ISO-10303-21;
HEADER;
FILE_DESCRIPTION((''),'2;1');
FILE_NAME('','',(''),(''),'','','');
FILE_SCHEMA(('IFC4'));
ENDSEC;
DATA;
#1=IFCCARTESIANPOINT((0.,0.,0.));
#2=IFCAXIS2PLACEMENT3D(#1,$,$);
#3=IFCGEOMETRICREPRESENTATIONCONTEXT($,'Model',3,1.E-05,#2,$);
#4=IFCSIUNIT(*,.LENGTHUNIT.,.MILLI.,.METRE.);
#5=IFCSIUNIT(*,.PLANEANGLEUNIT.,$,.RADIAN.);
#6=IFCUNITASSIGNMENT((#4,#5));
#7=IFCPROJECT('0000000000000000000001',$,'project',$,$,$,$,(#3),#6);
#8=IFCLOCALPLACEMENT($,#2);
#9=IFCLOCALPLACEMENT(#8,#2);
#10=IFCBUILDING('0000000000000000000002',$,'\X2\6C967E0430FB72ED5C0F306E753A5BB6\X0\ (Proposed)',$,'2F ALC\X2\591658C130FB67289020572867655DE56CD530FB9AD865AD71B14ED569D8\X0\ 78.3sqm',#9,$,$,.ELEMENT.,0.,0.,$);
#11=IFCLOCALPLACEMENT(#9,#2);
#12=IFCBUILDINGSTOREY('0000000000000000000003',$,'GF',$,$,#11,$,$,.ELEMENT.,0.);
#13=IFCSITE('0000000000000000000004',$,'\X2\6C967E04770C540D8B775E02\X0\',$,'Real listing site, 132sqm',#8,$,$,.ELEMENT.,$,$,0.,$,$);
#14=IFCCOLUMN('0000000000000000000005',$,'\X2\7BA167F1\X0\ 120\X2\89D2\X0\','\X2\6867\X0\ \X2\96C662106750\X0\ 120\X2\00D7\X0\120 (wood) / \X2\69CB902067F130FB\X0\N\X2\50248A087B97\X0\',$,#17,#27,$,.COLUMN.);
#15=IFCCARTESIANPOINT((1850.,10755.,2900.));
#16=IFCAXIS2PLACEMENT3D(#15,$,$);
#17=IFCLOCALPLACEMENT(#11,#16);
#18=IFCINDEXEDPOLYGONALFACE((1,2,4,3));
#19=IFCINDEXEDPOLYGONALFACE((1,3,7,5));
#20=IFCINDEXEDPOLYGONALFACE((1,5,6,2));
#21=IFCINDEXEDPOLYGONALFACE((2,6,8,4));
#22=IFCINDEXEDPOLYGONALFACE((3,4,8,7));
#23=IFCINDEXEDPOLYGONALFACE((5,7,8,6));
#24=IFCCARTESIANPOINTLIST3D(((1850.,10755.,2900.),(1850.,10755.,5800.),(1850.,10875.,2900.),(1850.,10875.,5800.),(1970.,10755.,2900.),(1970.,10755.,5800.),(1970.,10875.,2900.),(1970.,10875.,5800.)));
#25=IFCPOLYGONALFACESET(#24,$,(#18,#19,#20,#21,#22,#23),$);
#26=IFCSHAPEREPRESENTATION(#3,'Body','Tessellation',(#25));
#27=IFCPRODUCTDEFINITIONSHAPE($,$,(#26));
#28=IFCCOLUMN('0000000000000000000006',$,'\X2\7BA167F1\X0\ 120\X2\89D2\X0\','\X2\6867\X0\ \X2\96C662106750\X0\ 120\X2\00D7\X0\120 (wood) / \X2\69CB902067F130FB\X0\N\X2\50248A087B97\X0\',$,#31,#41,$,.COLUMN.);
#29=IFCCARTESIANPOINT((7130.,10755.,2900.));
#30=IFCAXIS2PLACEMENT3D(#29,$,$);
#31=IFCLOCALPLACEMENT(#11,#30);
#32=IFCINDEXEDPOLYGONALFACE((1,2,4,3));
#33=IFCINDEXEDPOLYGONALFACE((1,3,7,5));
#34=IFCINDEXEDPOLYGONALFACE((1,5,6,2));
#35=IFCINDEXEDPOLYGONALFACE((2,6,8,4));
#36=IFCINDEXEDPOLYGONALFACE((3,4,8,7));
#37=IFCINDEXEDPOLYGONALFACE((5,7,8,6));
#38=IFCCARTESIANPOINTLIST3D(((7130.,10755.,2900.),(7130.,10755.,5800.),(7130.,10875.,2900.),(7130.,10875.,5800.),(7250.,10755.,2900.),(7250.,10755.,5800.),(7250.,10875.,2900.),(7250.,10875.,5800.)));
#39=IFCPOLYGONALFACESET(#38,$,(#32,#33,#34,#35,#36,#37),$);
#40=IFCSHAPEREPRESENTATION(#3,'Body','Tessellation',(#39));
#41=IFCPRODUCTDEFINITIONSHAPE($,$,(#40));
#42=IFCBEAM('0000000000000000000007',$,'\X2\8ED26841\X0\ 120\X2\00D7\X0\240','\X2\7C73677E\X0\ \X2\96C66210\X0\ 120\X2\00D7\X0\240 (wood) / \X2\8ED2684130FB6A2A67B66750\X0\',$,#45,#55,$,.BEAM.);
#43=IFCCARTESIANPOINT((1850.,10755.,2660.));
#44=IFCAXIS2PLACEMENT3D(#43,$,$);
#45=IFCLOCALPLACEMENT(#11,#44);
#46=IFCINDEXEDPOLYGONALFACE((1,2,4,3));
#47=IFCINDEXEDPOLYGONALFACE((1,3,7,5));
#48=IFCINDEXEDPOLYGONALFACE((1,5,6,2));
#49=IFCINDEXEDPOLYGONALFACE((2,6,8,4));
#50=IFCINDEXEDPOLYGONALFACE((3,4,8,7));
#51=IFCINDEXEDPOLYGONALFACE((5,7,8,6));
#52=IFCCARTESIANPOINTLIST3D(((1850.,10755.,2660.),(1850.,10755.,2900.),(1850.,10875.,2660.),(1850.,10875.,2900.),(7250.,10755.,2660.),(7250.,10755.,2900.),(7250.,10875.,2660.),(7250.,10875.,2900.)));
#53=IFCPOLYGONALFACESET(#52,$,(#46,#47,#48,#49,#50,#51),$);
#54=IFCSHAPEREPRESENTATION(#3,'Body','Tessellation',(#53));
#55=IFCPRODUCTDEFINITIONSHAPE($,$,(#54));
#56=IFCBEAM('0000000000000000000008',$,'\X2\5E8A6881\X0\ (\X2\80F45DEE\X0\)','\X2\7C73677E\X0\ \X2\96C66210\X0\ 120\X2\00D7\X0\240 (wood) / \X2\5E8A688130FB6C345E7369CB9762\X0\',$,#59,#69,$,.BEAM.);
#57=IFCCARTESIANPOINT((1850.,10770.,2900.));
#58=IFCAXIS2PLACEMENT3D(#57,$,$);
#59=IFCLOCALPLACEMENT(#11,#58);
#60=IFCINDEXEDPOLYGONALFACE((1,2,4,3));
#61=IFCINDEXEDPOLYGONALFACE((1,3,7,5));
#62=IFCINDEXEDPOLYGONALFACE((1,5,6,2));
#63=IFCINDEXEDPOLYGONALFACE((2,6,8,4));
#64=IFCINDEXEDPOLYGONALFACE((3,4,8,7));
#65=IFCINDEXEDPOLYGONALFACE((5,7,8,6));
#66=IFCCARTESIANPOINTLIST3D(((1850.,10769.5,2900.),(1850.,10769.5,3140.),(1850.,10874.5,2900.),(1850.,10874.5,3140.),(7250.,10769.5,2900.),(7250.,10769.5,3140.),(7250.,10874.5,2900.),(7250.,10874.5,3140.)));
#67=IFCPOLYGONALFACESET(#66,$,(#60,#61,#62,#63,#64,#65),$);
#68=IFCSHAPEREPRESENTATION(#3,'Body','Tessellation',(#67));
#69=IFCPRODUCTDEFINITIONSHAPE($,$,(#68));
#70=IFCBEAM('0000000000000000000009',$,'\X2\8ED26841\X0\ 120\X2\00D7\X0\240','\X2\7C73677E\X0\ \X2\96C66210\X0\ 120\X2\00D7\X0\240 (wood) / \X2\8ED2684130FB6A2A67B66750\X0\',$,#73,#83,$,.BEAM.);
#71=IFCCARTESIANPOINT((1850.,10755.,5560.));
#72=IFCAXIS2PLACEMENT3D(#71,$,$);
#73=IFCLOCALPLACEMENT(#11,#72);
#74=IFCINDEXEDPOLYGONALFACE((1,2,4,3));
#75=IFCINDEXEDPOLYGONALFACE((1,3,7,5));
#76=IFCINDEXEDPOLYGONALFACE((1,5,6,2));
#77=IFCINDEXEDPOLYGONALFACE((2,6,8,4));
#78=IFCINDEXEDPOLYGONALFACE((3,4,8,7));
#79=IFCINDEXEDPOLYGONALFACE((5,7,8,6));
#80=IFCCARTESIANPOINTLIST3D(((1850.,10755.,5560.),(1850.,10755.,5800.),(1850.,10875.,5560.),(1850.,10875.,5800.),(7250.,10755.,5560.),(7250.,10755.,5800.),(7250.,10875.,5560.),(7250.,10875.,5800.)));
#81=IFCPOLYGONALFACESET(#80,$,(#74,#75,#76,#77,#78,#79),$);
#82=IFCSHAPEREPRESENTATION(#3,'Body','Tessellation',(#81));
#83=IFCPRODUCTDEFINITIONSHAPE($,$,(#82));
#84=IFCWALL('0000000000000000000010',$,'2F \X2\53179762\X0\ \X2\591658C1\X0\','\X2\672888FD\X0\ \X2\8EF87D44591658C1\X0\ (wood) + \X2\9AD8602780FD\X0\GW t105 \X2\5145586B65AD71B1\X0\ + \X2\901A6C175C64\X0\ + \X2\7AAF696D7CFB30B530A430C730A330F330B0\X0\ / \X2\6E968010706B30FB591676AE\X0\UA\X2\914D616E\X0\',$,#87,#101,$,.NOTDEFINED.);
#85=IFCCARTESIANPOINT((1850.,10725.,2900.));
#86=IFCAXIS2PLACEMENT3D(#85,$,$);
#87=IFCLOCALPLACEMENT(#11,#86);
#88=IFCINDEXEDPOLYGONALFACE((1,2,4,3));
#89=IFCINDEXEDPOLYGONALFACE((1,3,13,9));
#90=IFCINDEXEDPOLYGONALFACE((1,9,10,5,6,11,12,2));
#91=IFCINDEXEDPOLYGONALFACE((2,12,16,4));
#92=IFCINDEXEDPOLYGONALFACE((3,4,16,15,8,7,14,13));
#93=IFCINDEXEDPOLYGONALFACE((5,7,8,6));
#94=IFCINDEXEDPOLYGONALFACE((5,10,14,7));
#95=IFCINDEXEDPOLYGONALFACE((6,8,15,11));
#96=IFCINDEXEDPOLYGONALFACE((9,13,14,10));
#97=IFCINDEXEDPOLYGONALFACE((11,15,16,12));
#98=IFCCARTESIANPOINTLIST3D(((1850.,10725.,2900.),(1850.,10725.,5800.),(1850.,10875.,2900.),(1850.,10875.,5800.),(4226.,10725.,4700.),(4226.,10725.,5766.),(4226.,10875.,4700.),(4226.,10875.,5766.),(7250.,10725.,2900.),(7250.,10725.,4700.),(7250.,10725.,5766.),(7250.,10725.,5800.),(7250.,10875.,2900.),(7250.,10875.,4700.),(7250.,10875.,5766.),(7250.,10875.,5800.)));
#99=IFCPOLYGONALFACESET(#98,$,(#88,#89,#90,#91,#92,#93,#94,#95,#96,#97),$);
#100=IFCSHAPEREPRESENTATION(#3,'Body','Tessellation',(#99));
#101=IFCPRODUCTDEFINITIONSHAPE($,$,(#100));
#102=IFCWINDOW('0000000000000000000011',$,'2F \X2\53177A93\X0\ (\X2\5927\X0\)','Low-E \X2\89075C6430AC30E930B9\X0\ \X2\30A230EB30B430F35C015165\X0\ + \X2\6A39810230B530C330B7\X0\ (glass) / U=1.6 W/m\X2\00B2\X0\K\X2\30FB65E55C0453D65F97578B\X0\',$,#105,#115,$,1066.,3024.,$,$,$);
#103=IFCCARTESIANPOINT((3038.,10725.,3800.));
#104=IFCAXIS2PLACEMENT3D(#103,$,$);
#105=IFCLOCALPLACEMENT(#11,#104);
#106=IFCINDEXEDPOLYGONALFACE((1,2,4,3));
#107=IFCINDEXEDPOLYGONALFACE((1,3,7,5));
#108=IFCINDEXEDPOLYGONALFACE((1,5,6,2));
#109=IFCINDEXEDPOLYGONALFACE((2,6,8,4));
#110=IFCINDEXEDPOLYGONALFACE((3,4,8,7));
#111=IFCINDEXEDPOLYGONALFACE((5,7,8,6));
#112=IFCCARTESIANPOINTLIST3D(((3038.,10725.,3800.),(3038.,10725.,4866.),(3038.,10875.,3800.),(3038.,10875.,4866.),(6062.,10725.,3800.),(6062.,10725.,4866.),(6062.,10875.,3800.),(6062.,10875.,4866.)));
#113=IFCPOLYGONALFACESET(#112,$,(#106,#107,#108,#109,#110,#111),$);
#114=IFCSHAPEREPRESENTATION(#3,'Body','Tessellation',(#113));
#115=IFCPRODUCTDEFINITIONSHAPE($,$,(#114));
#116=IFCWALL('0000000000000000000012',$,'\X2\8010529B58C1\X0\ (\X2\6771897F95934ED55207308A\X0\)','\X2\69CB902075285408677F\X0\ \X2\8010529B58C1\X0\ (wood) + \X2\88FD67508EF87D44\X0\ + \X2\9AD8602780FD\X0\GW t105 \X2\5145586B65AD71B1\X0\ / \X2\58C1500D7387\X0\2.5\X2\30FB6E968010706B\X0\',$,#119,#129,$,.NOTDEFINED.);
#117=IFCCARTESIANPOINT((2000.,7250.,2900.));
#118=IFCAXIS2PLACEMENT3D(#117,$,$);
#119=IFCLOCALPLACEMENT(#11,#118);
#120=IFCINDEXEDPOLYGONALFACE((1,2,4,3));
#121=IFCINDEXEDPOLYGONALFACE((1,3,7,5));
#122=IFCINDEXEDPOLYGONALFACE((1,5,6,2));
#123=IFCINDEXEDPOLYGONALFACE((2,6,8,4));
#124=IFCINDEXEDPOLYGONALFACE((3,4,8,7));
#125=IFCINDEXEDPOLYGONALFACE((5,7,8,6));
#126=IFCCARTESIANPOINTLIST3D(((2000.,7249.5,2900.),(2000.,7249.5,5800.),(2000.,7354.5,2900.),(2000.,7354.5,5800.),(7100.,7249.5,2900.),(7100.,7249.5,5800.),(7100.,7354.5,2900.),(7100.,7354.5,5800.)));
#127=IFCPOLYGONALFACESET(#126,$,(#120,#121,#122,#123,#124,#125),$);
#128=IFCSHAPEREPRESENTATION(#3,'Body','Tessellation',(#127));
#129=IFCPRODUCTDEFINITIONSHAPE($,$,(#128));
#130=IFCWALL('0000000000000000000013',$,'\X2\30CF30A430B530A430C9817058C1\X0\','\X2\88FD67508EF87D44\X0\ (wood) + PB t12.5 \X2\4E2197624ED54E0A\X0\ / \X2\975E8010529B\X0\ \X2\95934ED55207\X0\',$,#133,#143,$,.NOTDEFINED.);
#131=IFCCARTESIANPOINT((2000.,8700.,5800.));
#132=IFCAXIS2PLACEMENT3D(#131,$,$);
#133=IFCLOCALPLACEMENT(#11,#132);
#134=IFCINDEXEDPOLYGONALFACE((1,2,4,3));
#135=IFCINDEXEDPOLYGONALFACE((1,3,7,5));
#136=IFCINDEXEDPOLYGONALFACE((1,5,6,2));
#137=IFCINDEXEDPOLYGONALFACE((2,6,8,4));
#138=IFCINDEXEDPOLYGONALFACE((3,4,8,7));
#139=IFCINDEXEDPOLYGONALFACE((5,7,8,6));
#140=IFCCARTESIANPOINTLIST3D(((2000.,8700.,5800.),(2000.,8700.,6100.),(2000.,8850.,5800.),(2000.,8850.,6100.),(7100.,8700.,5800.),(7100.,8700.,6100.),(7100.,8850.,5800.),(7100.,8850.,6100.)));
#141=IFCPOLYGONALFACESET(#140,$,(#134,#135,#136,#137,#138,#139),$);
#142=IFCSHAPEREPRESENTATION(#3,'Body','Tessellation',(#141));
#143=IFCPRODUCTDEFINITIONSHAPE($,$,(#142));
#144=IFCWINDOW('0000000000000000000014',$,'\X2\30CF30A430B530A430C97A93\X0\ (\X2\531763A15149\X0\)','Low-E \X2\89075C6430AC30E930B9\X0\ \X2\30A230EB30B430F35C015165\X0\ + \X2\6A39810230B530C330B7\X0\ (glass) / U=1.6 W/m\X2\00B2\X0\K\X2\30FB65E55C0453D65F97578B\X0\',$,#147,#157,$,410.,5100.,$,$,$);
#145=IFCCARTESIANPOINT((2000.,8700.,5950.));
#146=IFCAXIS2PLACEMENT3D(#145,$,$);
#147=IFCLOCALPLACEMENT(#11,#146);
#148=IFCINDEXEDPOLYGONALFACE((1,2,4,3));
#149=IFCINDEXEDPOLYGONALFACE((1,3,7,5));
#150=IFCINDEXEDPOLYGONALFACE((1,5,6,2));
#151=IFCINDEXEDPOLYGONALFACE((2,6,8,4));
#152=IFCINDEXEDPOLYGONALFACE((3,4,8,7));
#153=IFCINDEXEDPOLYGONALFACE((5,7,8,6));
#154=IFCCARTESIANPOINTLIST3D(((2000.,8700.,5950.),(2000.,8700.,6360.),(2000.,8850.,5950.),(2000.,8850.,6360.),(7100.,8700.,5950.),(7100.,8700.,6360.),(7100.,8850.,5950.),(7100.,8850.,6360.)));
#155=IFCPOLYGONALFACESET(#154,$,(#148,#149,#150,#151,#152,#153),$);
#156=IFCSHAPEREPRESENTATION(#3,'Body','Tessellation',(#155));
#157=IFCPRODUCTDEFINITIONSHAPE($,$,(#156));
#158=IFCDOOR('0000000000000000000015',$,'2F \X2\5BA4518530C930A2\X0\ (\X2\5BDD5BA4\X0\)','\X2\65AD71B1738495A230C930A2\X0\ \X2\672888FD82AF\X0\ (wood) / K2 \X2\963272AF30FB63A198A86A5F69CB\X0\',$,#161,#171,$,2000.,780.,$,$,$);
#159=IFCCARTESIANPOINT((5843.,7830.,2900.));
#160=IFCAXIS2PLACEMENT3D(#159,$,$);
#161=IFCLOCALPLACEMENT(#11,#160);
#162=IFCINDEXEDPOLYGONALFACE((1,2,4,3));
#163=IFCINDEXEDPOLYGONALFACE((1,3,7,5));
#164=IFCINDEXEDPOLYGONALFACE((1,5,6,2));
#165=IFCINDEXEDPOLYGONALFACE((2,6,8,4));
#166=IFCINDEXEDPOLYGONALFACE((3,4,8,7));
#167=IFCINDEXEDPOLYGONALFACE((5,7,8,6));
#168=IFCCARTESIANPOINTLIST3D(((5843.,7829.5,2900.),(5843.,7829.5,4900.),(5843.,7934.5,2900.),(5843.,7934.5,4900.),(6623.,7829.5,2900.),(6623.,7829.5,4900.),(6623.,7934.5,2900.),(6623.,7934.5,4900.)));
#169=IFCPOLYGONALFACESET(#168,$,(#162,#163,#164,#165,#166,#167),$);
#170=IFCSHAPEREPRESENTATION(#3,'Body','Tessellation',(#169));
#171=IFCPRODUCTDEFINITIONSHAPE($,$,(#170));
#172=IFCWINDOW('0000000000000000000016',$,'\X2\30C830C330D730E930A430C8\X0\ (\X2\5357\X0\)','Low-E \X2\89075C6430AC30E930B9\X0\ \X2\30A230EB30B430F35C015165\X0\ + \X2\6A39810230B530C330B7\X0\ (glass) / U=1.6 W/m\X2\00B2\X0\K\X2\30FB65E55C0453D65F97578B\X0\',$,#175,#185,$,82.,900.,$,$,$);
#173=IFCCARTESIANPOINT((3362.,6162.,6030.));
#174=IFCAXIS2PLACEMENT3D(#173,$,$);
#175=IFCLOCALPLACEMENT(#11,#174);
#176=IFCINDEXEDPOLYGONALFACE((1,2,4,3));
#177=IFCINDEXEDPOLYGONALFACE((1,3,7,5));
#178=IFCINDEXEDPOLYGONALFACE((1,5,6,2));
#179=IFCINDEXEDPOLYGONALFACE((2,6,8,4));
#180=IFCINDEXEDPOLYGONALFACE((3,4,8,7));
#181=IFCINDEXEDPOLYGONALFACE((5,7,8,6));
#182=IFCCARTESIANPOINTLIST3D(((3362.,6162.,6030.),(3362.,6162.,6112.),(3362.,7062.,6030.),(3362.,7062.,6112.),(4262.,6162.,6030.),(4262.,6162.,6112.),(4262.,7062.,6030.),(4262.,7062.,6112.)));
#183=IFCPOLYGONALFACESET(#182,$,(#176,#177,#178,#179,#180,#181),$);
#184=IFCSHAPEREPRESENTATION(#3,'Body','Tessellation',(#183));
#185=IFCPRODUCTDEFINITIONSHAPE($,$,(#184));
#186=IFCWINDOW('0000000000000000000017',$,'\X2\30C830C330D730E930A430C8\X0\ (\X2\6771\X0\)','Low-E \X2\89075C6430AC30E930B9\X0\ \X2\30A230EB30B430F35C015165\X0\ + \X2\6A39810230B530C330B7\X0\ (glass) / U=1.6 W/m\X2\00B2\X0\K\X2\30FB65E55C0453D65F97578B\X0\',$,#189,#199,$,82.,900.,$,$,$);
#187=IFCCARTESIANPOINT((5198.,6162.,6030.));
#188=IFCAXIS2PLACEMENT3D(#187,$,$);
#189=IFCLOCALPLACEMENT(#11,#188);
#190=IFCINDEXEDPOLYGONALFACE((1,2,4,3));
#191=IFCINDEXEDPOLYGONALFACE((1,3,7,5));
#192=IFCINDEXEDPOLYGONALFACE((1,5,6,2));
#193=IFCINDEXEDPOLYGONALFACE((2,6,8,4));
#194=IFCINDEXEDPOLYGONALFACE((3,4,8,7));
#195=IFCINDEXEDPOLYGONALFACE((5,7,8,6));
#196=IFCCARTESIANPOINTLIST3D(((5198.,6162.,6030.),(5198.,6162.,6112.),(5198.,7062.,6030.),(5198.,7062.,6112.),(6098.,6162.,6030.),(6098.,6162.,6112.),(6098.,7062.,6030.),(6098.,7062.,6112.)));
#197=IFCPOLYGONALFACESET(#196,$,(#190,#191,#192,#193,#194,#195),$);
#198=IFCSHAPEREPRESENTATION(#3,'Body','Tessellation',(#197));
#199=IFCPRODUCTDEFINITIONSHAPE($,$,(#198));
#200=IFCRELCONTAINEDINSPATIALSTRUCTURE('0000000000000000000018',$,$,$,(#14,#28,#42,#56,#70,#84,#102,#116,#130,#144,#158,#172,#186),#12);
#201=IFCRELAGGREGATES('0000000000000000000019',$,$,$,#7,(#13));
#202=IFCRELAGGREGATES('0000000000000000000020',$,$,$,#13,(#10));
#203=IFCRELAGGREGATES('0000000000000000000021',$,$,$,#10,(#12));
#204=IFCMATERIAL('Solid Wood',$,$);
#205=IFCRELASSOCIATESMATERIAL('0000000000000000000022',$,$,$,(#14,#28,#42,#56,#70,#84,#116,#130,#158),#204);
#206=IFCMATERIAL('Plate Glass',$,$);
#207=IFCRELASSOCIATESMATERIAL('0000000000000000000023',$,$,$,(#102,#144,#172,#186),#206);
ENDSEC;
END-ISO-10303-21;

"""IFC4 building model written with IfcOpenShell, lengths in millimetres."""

from ifc_helpers import new_model, si_unit, frame, frame_2d, origin, place, context, project, spatial, rectangle, extrude, material, element, fill, save


model = new_model("IFC4")

# Units and contexts
model_context = context("Model", 3, precision=1e-05, world=origin())
ifc_project = project(units=[si_unit("LENGTHUNIT", "METRE", prefix="MILLI"), si_unit("PLANEANGLEUNIT", "RADIAN")], contexts=[model_context])

# Site, building, storey
site_placement = place(None, origin())
site = spatial("IfcSite", under=ifc_project, at=site_placement, Name="沖縄県名護市", ObjectType="Real listing site, 132sqm", CompositionType="ELEMENT", RefElevation=0.0)
building_placement = place(site_placement, origin())
building = spatial("IfcBuilding", under=site, at=building_placement, Name="沖縄・狭小の町家 (Proposed)", ObjectType="2F ALC外壁・木造在来工法・高断熱仕様 78.3sqm", CompositionType="ELEMENT", ElevationOfRefHeight=0.0, ElevationOfTerrain=0.0)
storey_placement = place(building_placement, origin())
storey = spatial("IfcBuildingStorey", under=building, at=storey_placement, Name="GF", CompositionType="ELEMENT", Elevation=0.0)

# Columns
ifc_material_1 = material(Name="Solid Wood")
column_1_placement = place(storey_placement, frame((1850.0, 10755.0, 2900.0)))
element("IfcColumn", 1, at=column_1_placement, inside=storey, material=ifc_material_1, Name="管柱 120角", Description="桧 集成材 120×120 (wood) / 構造柱・N値計算", PredefinedType="COLUMN", context=model_context, shape_type="SweptSolid", body=[
    extrude(rectangle(XDim=120.0, YDim=120.0, at=frame_2d((60.0, 60.0))), frame((1850.0, 10755.0, 2900.0)), (0.0, 0.0, 1.0), 2900.0),
])
column_2_placement = place(storey_placement, frame((7130.0, 10755.0, 2900.0)))
element("IfcColumn", 2, at=column_2_placement, inside=storey, material=ifc_material_1, Name="管柱 120角", Description="桧 集成材 120×120 (wood) / 構造柱・N値計算", PredefinedType="COLUMN", context=model_context, shape_type="SweptSolid", body=[
    extrude(rectangle(XDim=120.0, YDim=120.0, at=frame_2d((60.0, 60.0))), frame((7130.0, 10755.0, 2900.0)), (0.0, 0.0, 1.0), 2900.0),
])

# Beams
beam_1_placement = place(storey_placement, frame((1850.0, 10755.0, 2660.0)))
element("IfcBeam", 3, at=beam_1_placement, inside=storey, material=ifc_material_1, Name="軒桁 120×240", Description="米松 集成 120×240 (wood) / 軒桁・横架材", PredefinedType="BEAM", context=model_context, shape_type="SweptSolid", body=[
    extrude(rectangle(XDim=5400.0, YDim=120.0, at=frame_2d((2700.0, 60.0))), frame((1850.0, 10755.0, 2660.0)), (0.0, 0.0, 1.0), 240.0),
])
beam_2_placement = place(storey_placement, frame((1850.0, 10770.0, 2900.0)))
element("IfcBeam", 4, at=beam_2_placement, inside=storey, material=ifc_material_1, Name="床梁 (胴差)", Description="米松 集成 120×240 (wood) / 床梁・水平構面", PredefinedType="BEAM", context=model_context, shape_type="SweptSolid", body=[
    extrude(rectangle(XDim=5400.0, YDim=105.0, at=frame_2d((2700.0, 52.0))), frame((1850.0, 10770.0, 2900.0)), (0.0, 0.0, 1.0), 240.0),
])
beam_3_placement = place(storey_placement, frame((1850.0, 10755.0, 5560.0)))
element("IfcBeam", 5, at=beam_3_placement, inside=storey, material=ifc_material_1, Name="軒桁 120×240", Description="米松 集成 120×240 (wood) / 軒桁・横架材", PredefinedType="BEAM", context=model_context, shape_type="SweptSolid", body=[
    extrude(rectangle(XDim=5400.0, YDim=120.0, at=frame_2d((2700.0, 60.0))), frame((1850.0, 10755.0, 5560.0)), (0.0, 0.0, 1.0), 240.0),
])

# Wall, opening, window
wall_1_placement = place(storey_placement, frame((1850.0, 10725.0, 2900.0)))
wall_1 = element("IfcWall", 6, at=wall_1_placement, inside=storey, material=ifc_material_1, Name="2F 北面 外壁", Description="木製 軸組外壁 (wood) + 高性能GW t105 充填断熱 + 通気層 + 窯業系サイディング / 準耐火・外皮UA配慮", PredefinedType="NOTDEFINED", context=model_context, shape_type="SweptSolid", body=[
    extrude(rectangle(XDim=5400.0, YDim=150.0, at=frame_2d((2700.0, 75.0))), frame((1850.0, 10725.0, 2900.0)), (0.0, 0.0, 1.0), 2900.0),
])
opening_1_placement = place(storey_placement, frame((3038.0, 10725.0, 3800.0)))
opening_1 = element("IfcOpeningElement", 7, at=opening_1_placement, cuts=wall_1, PredefinedType="NOTDEFINED", context=model_context, shape_type="SweptSolid", body=[
    extrude(rectangle(XDim=3024.0, YDim=150.0, at=frame_2d((1512.0, 75.0))), frame((3038.0, 10725.0, 3800.0)), (0.0, 0.0, 1.0), 1066.0),
])
ifc_material_2 = material(Name="Plate Glass")
window_1_placement = place(storey_placement, frame((3038.0, 10725.0, 3800.0)))
window_1 = element("IfcWindow", 8, at=window_1_placement, inside=storey, material=ifc_material_2, Name="2F 北窓 (大)", Description="Low-E 複層ガラス アルゴン封入 + 樹脂サッシ (glass) / U=1.6 W/m²K・日射取得型", OverallHeight=1066.0, OverallWidth=3024.0, context=model_context, shape_type="SweptSolid", body=[
    extrude(rectangle(XDim=3024.0, YDim=150.0, at=frame_2d((1512.0, 75.0))), frame((3038.0, 10725.0, 3800.0)), (0.0, 0.0, 1.0), 1066.0),
])
fill(opening_1, window_1)

# Wall
wall_2_placement = place(storey_placement, frame((2000.0, 7250.0, 2900.0)))
element("IfcWall", 9, at=wall_2_placement, inside=storey, material=ifc_material_1, Name="耐力壁 (東西間仕切り)", Description="構造用合板 耐力壁 (wood) + 製材軸組 + 高性能GW t105 充填断熱 / 壁倍率2.5・準耐火", PredefinedType="NOTDEFINED", context=model_context, shape_type="SweptSolid", body=[
    extrude(rectangle(XDim=5100.0, YDim=105.0, at=frame_2d((2550.0, 52.0))), frame((2000.0, 7250.0, 2900.0)), (0.0, 0.0, 1.0), 2900.0),
])

# Wall, opening, window
wall_3_placement = place(storey_placement, frame((2000.0, 8700.0, 5800.0)))
wall_3 = element("IfcWall", 10, at=wall_3_placement, inside=storey, material=ifc_material_1, Name="ハイサイド腰壁", Description="製材軸組 (wood) + PB t12.5 両面仕上 / 非耐力 間仕切", PredefinedType="NOTDEFINED", context=model_context, shape_type="SweptSolid", body=[
    extrude(rectangle(XDim=5100.0, YDim=150.0, at=frame_2d((2550.0, 75.0))), frame((2000.0, 8700.0, 5800.0)), (0.0, 0.0, 1.0), 700.0),
])
opening_2_placement = place(storey_placement, frame((2000.0, 8700.0, 5950.0)))
opening_2 = element("IfcOpeningElement", 11, at=opening_2_placement, cuts=wall_3, PredefinedType="NOTDEFINED", context=model_context, shape_type="SweptSolid", body=[
    extrude(rectangle(XDim=5100.0, YDim=150.0, at=frame_2d((2550.0, 75.0))), frame((2000.0, 8700.0, 5950.0)), (0.0, 0.0, 1.0), 410.0),
])
window_2_placement = place(storey_placement, frame((2000.0, 8700.0, 5950.0)))
window_2 = element("IfcWindow", 12, at=window_2_placement, inside=storey, material=ifc_material_2, Name="ハイサイド窓 (北採光)", Description="Low-E 複層ガラス アルゴン封入 + 樹脂サッシ (glass) / U=1.6 W/m²K・日射取得型", OverallHeight=410.0, OverallWidth=5100.0, context=model_context, shape_type="SweptSolid", body=[
    extrude(rectangle(XDim=5100.0, YDim=150.0, at=frame_2d((2550.0, 75.0))), frame((2000.0, 8700.0, 5950.0)), (0.0, 0.0, 1.0), 410.0),
])
fill(opening_2, window_2)

# Door
door_placement = place(storey_placement, frame((5843.0, 7830.0, 2900.0)))
element("IfcDoor", 13, at=door_placement, inside=storey, material=ifc_material_1, Name="2F 室内ドア (寝室)", Description="断熱玄関ドア 木製芯 (wood) / K2 防犯・採風機構", OverallHeight=2000.0, OverallWidth=780.0, context=model_context, shape_type="SweptSolid", body=[
    extrude(rectangle(XDim=780.0, YDim=105.0, at=frame_2d((390.0, 52.0))), frame((5843.0, 7830.0, 2900.0)), (0.0, 0.0, 1.0), 2000.0),
])

# Windows
window_3_placement = place(storey_placement, frame((3362.0, 6162.0, 6030.0)))
element("IfcWindow", 14, at=window_3_placement, inside=storey, material=ifc_material_2, Name="トップライト (南)", Description="Low-E 複層ガラス アルゴン封入 + 樹脂サッシ (glass) / U=1.6 W/m²K・日射取得型", OverallHeight=82.0, OverallWidth=900.0, context=model_context, shape_type="SweptSolid", body=[
    extrude(rectangle(XDim=900.0, YDim=900.0, at=frame_2d((450.0, 450.0))), frame((3362.0, 6162.0, 6030.0)), (0.0, 0.0, 1.0), 82.0),
])
window_4_placement = place(storey_placement, frame((5198.0, 6162.0, 6030.0)))
element("IfcWindow", 15, at=window_4_placement, inside=storey, material=ifc_material_2, Name="トップライト (東)", Description="Low-E 複層ガラス アルゴン封入 + 樹脂サッシ (glass) / U=1.6 W/m²K・日射取得型", OverallHeight=82.0, OverallWidth=900.0, context=model_context, shape_type="SweptSolid", body=[
    extrude(rectangle(XDim=900.0, YDim=900.0, at=frame_2d((450.0, 450.0))), frame((5198.0, 6162.0, 6030.0)), (0.0, 0.0, 1.0), 82.0),
])

save(model, "model.ifc")
